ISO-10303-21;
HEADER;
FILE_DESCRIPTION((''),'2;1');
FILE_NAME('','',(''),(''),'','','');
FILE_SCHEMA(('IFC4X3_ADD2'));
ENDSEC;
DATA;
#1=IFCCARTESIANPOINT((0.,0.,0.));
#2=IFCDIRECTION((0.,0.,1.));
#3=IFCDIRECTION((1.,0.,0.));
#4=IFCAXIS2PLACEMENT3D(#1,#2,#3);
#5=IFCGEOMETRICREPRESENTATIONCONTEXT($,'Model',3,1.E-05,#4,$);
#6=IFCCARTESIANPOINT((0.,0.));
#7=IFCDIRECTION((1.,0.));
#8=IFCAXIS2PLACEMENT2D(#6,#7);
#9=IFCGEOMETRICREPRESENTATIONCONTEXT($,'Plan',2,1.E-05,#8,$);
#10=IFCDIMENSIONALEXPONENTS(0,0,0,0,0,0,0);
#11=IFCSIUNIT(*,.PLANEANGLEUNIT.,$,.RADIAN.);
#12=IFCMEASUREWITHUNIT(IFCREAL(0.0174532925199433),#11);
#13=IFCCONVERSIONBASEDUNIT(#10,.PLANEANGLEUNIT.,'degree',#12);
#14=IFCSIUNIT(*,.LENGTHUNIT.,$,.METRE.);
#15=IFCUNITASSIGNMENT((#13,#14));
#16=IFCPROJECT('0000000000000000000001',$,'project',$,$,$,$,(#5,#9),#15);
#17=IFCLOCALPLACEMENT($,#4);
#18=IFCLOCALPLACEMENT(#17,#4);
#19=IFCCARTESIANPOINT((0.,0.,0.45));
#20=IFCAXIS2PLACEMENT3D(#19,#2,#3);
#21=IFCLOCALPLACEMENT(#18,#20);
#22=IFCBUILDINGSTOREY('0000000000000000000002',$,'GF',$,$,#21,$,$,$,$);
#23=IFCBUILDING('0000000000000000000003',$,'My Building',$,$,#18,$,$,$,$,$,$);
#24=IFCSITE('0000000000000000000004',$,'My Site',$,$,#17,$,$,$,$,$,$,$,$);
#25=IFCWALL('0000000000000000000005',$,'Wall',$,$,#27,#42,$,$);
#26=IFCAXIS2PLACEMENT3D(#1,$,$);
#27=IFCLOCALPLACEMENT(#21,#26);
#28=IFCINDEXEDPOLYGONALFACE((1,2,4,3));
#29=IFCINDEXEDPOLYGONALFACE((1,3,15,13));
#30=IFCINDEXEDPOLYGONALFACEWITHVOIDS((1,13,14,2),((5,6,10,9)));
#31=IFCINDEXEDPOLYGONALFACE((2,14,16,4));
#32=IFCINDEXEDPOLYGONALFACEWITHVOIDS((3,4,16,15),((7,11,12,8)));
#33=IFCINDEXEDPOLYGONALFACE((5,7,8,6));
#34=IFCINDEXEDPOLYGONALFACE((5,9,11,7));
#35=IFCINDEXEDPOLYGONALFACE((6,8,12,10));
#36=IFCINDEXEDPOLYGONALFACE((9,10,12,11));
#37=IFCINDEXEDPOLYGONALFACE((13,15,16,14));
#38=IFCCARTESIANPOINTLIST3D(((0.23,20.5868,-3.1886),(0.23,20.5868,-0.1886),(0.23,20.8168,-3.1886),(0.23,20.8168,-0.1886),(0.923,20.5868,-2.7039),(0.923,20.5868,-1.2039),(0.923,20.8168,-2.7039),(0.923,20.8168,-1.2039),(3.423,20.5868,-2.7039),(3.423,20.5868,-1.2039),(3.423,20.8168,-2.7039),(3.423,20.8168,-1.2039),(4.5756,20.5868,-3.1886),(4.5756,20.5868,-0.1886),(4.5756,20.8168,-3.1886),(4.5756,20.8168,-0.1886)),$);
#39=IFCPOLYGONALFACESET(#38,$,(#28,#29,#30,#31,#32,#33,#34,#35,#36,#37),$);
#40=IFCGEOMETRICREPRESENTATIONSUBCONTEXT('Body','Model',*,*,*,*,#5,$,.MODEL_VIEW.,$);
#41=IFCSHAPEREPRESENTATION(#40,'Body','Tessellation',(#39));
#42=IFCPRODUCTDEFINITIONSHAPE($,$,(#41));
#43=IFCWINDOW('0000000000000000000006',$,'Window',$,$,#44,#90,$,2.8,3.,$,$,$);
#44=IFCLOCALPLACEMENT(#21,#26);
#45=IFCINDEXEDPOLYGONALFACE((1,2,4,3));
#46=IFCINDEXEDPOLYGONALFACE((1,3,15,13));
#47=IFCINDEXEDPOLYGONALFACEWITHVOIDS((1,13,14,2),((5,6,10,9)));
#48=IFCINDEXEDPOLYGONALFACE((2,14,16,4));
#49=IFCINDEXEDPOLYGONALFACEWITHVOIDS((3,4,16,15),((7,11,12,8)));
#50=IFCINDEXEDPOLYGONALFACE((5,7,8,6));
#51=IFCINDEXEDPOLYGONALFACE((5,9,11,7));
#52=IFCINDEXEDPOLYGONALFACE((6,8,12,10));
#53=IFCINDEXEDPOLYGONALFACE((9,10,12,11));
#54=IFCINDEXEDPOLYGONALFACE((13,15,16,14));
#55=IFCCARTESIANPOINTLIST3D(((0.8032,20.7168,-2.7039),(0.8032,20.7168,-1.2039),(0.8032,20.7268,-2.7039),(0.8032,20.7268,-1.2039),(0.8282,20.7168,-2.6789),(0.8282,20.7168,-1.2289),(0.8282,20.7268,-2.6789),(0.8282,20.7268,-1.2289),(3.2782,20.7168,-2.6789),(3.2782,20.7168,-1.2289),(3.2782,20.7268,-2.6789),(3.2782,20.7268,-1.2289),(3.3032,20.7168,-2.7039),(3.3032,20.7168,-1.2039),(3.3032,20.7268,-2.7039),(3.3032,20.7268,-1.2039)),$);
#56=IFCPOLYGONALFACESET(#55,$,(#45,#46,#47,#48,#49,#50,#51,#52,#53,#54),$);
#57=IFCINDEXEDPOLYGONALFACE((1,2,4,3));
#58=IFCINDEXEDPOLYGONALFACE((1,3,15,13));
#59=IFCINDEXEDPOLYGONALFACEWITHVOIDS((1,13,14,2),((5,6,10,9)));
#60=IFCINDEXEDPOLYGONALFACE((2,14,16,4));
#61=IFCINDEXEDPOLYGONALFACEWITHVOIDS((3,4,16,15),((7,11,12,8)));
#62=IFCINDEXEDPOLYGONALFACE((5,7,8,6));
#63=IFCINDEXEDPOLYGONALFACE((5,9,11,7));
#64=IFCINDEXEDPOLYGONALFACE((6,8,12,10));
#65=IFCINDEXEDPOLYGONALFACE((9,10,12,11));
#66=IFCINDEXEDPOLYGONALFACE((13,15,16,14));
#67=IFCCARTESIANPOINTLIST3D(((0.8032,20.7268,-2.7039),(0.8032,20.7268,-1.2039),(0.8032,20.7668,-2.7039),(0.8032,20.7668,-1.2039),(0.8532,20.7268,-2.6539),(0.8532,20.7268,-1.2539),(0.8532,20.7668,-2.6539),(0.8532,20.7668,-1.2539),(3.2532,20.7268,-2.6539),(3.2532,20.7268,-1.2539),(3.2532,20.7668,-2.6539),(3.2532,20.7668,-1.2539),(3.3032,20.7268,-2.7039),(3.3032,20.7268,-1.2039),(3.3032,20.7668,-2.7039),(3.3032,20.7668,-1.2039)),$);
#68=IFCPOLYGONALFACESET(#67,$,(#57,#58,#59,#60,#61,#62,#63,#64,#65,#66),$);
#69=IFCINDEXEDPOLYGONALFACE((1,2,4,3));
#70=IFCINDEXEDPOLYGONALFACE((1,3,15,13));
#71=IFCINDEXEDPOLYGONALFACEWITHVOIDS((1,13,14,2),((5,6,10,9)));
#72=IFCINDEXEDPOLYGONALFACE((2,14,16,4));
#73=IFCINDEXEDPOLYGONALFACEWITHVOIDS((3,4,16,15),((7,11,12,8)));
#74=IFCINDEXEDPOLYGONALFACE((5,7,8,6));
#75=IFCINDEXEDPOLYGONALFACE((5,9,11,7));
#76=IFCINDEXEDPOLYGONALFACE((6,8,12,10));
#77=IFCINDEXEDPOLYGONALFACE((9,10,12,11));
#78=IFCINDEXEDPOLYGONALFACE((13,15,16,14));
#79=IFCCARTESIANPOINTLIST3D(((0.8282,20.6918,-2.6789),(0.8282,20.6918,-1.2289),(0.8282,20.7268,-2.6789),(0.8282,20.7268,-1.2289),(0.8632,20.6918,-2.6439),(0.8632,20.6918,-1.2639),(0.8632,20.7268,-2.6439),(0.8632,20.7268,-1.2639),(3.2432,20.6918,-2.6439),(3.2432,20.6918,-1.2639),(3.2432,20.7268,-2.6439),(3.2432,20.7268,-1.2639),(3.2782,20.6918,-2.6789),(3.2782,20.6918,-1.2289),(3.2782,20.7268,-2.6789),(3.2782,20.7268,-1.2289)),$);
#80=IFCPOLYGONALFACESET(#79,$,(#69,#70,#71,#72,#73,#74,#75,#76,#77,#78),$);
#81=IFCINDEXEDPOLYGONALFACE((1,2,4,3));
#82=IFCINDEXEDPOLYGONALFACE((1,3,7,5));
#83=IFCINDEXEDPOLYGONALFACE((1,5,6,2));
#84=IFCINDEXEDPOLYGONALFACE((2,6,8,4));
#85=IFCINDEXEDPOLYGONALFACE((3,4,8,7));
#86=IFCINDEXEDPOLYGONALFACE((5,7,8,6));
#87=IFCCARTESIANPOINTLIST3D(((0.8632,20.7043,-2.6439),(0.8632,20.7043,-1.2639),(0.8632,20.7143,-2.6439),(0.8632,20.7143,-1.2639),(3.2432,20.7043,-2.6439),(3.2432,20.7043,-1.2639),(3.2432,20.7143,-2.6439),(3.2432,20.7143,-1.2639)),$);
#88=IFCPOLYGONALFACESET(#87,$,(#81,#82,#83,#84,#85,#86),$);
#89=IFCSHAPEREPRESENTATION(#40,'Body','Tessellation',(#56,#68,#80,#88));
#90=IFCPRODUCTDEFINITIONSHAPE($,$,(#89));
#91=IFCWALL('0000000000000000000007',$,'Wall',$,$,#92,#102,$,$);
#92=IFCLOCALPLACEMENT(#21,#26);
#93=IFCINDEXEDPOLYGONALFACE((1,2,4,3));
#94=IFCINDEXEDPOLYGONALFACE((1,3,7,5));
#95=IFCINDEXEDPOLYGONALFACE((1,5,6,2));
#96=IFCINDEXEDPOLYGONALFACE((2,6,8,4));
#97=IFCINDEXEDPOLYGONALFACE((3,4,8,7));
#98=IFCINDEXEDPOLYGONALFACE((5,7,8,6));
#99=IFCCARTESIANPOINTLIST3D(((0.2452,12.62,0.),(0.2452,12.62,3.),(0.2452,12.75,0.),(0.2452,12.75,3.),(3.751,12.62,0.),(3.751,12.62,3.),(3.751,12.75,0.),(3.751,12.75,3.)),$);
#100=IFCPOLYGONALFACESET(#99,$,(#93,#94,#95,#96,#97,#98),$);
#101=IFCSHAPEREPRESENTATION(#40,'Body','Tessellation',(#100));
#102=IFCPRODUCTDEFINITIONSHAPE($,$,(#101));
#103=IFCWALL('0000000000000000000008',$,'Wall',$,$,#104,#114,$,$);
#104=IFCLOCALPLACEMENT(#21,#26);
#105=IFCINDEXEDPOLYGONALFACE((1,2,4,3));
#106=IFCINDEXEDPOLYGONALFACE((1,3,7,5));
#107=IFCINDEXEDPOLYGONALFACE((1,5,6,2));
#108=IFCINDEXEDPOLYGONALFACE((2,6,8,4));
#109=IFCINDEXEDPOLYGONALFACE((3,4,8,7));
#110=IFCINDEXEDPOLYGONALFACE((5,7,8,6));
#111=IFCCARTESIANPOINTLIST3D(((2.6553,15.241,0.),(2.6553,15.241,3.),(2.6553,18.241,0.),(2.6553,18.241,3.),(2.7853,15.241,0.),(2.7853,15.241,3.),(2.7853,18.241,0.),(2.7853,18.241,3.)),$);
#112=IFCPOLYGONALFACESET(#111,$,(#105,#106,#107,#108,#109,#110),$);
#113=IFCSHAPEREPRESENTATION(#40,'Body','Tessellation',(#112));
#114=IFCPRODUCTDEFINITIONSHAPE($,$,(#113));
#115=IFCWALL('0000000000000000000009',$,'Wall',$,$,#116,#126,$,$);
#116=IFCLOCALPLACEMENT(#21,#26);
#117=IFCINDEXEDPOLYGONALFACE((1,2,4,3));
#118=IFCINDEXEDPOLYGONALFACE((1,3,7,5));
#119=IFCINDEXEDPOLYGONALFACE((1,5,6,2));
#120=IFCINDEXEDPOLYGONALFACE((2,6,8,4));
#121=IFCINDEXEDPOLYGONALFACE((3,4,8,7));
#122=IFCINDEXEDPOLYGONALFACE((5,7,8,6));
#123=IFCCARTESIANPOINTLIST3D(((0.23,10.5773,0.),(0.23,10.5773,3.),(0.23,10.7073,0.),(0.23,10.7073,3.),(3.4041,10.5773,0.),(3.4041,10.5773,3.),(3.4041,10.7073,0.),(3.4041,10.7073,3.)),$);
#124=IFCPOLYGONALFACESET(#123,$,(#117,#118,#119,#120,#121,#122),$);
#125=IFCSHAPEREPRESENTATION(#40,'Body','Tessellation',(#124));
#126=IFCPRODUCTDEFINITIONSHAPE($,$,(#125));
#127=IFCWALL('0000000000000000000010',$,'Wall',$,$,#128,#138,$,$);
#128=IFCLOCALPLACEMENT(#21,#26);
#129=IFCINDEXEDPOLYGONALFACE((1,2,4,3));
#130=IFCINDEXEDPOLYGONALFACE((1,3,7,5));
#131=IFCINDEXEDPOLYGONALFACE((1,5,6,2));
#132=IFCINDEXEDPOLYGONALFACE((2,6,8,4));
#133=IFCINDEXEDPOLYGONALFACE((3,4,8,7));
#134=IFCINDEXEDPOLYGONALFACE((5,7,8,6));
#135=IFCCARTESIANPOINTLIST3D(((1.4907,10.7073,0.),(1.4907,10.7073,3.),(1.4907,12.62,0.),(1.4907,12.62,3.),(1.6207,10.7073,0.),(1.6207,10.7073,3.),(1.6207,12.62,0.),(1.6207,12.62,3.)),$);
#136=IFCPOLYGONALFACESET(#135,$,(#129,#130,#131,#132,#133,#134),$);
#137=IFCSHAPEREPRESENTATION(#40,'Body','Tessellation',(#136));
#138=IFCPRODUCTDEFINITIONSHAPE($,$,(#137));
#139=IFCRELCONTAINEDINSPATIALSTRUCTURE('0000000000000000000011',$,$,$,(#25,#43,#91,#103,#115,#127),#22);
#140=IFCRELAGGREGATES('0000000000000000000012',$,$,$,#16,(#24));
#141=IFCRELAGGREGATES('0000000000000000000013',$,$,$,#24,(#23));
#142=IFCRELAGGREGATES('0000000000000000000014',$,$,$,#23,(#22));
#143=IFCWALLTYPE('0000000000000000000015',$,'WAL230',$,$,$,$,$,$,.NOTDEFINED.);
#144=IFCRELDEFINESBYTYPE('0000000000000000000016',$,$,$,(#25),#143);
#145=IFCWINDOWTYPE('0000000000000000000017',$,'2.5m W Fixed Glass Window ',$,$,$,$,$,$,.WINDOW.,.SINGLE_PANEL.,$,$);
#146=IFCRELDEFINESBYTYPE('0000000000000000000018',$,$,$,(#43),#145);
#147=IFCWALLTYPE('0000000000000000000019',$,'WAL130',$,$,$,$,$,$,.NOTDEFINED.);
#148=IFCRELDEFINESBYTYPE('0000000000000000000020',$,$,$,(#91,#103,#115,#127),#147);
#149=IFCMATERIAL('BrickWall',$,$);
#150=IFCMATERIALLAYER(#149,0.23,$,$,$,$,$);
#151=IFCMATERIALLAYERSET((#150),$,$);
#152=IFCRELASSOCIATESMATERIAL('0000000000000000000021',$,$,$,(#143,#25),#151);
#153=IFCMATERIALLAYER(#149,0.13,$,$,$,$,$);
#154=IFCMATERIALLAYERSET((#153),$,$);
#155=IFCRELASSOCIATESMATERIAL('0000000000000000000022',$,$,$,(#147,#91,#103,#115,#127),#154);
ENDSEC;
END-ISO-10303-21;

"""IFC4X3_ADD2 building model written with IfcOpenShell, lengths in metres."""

from ifc_helpers import new_model, entity, si_unit, converted_unit, frame, origin_with_axes, origin_2d_with_axis, place, context, subcontext, project, spatial, line, indexed_curve, outline, extrude, shape, source, transform, mapped, material, layer, layer_set, layer_usage, type_object, type_shapes, element, fill, save


model = new_model("IFC4X3_ADD2")

# Units and contexts
model_context = context("Model", 3, precision=1e-05, world=origin_with_axes())
plan_context = context("Plan", 2, precision=1e-05, world=origin_2d_with_axis())
body_context_1 = subcontext(model_context, "Body", "Model", "MODEL_VIEW")
body_context_2 = subcontext(plan_context, "Body", "Plan", "PLAN_VIEW")
ifc_project = project(units=[converted_unit("PLANEANGLEUNIT", "degree", entity("IfcReal", 0.0174532925199433), si_unit("PLANEANGLEUNIT", "RADIAN"), dimensions=[0, 0, 0, 0, 0, 0, 0]), si_unit("LENGTHUNIT", "METRE")], contexts=[model_context, plan_context])

# Site, building, storey
site_placement = place(None, origin_with_axes())
site = spatial("IfcSite", under=ifc_project, at=site_placement, Name="My Site")
building_placement = place(site_placement, origin_with_axes())
building = spatial("IfcBuilding", under=site, at=building_placement, Name="My Building")
storey_placement = place(building_placement, frame((0.0, 0.0, 0.45), z_axis=(0.0, 0.0, 1.0), x_axis=(1.0, 0.0, 0.0)))
storey = spatial("IfcBuildingStorey", under=building, at=storey_placement, Name="GF")

# Shared definitions
ifc_material_1 = material(Name="BrickWall")
ifc_layer_1 = layer(ifc_material_1, 0.23)
ifc_layer_set_1 = layer_set([ifc_layer_1])
wall_type_1 = type_object("IfcWallType", Name="WAL230", PredefinedType="NOTDEFINED", material=ifc_layer_set_1)
shared_shape_1 = source(origin_with_axes(), body_context_1, "Body", "SweptSolid", [
    extrude(outline(indexed_curve([(0.0, 0.0), (2.5, 0.0), (2.5, 1.5), (0.0, 1.5)], segments=[line(1, 2, 3, 4, 1)])), frame((0.0, -0.6, 0.0), z_axis=(0.0, -1.0, 0.0), x_axis=(1.0, 0.0, 0.0)), (0.0, 0.0, -1.0), 1.2),
])
window_type_1 = type_object("IfcWindowType", Name="2.5m W Fixed Glass Window ", PartitioningType="SINGLE_PANEL", PredefinedType="WINDOW")
shared_shape_2 = source(origin_with_axes(), body_context_1, "Body", "SweptSolid", [
    extrude(outline(indexed_curve([(0.0, 0.0), (2.5, 0.0), (2.5, 1.5), (0.0, 1.5)], segments=[line(1, 2, 3, 4, 1)]), holes=[indexed_curve([(0.025, 0.025), (2.475, 0.025), (2.475, 1.475), (0.025, 1.475)], segments=[line(1, 2, 3, 4, 1)])]), frame((0.0, 0.09, 0.0), z_axis=(0.0, -1.0, 0.0), x_axis=(1.0, 0.0, 0.0)), (0.0, 0.0, -1.0), 0.01),
    extrude(outline(indexed_curve([(0.0, 0.0), (2.5, 0.0), (2.5, 1.5), (0.0, 1.5)], segments=[line(1, 2, 3, 4, 1)]), holes=[indexed_curve([(0.05, 0.05), (2.45, 0.05), (2.45, 1.45), (0.05, 1.45)], segments=[line(1, 2, 3, 4, 1)])]), frame((0.0, 0.05, 0.0), z_axis=(0.0, -1.0, 0.0), x_axis=(1.0, 0.0, 0.0)), (0.0, 0.0, -1.0), 0.04),
    extrude(outline(indexed_curve([(0.0, 0.0), (2.45, 0.0), (2.45, 1.45), (0.0, 1.45)], segments=[line(1, 2, 3, 4, 1)]), holes=[indexed_curve([(0.035, 0.035), (2.415, 0.035), (2.415, 1.415), (0.035, 1.415)], segments=[line(1, 2, 3, 4, 1)])]), frame((0.025, 0.09, 0.025), z_axis=(0.0, -1.0, 0.0), x_axis=(1.0, 0.0, 0.0)), (0.0, 0.0, -1.0), 0.035),
    extrude(outline(indexed_curve([(0.035, 0.035), (2.415, 0.035), (2.415, 1.415), (0.035, 1.415)], segments=[line(1, 2, 3, 4, 1)])), frame((0.025, 0.1025, 0.025), z_axis=(0.0, -1.0, 0.0), x_axis=(1.0, 0.0, 0.0)), (0.0, 0.0, -1.0), 0.01),
])
shared_shape_3 = source(origin_with_axes(), body_context_2, "Body", "Curve2D", [
    entity("IfcIndexedPolyCurve", entity("IfcCartesianPointList2D", [[0.05, 0.05], [2.45, 0.05]])),
    entity("IfcIndexedPolyCurve", entity("IfcCartesianPointList2D", [[0.0, 0.1], [0.025, 0.1], [0.025, 0.09], [0.05, 0.09], [0.05, 0.05], [0.0, 0.05]]), [entity("IfcLineIndex", [1, 2, 3, 4, 5, 6, 1])]),
    entity("IfcIndexedPolyCurve", entity("IfcCartesianPointList2D", [[2.5, 0.1], [2.475, 0.1], [2.475, 0.09], [2.45, 0.09], [2.45, 0.05], [2.5, 0.05]]), [entity("IfcLineIndex", [1, 2, 3, 4, 5, 6, 1])]),
    entity("IfcIndexedPolyCurve", entity("IfcCartesianPointList2D", [[0.025, 0.09], [0.06, 0.09], [0.06, 0.125], [0.025, 0.125]]), [entity("IfcLineIndex", [1, 2, 3, 4, 1])]),
    entity("IfcIndexedPolyCurve", entity("IfcCartesianPointList2D", [[2.475, 0.09], [2.44, 0.09], [2.44, 0.125], [2.475, 0.125]]), [entity("IfcLineIndex", [1, 2, 3, 4, 1])]),
    entity("IfcIndexedPolyCurve", entity("IfcCartesianPointList2D", [[0.06, 0.09], [2.44, 0.09]])),
    entity("IfcIndexedPolyCurve", entity("IfcCartesianPointList2D", [[0.06, 0.125], [2.44, 0.125]])),
    entity("IfcIndexedPolyCurve", entity("IfcCartesianPointList2D", [[0.06, 0.1075], [2.44, 0.1075]])),
])
type_shapes(window_type_1, [shared_shape_2, shared_shape_3])

# Wall, opening, window
ifc_layer_usage_1 = layer_usage(ifc_layer_set_1, "AXIS2", "POSITIVE", 0.0)
wall_1_placement = place(storey_placement, frame((4.5756, 20.8168, -3.1886), z_axis=(0.0, 0.0, 1.0), x_axis=(-1.0, 0.0, 0.0)))
wall_1 = element("IfcWall", 1, at=wall_1_placement, inside=storey, type_object=wall_type_1, material=ifc_layer_usage_1, Name="Wall", context=body_context_1, shape_type="SweptSolid", body=[
    extrude(outline(indexed_curve([(0.0, 0.0), (0.0, 0.23), (4.3456, 0.23), (4.3456, 0.0), (0.0, 0.0)], self_intersect=False)), origin_with_axes(), (0.0, 0.0, 1.0), 3.0),
])
opening_1_placement = place(wall_1_placement, frame((1.1526, 0.0, 0.4847), z_axis=(0.0, 0.0, 1.0), x_axis=(1.0, 0.0, 0.0)))
opening_1 = element("IfcOpeningElement", 2, at=opening_1_placement, cuts=wall_1, PredefinedType="OPENING", context=body_context_1, shape_type="MappedRepresentation", body=[
    mapped(shared_shape_1, transform((0.0, 0.0, 0.0), x_axis=(1.0, 0.0, 0.0), y_axis=(0.0, 1.0, 0.0), z_axis=(0.0, 0.0, 1.0), scale=1.0)),
])
window_1_placement = place(opening_1_placement, frame((0.1197, 0.0, 0.0), z_axis=(0.0, 0.0, 1.0), x_axis=(1.0, 0.0, 0.0)))
window_1 = element("IfcWindow", 3, at=window_1_placement, inside=storey, type_object=window_type_1, Name="Window", OverallHeight=2.8, OverallWidth=3.0, shapes=[
    shape(body_context_1, "Body", "MappedRepresentation", [mapped(shared_shape_2, transform((0.0, 0.0, 0.0), x_axis=(1.0, 0.0, 0.0), y_axis=(0.0, 1.0, 0.0), z_axis=(0.0, 0.0, 1.0), scale=1.0))]),
    shape(body_context_2, "Body", "MappedRepresentation", [mapped(shared_shape_3, transform((0.0, 0.0, 0.0), x_axis=(1.0, 0.0, 0.0), y_axis=(0.0, 1.0, 0.0), z_axis=(0.0, 0.0, 1.0), scale=1.0))]),
])
fill(opening_1, window_1)

# Walls
ifc_layer_2 = layer(ifc_material_1, 0.13)
ifc_layer_set_2 = layer_set([ifc_layer_2])
ifc_layer_usage_2 = layer_usage(ifc_layer_set_2, "AXIS2", "POSITIVE", 0.0)
wall_type_2 = type_object("IfcWallType", Name="WAL130", PredefinedType="NOTDEFINED", material=ifc_layer_set_2)
wall_2_placement = place(storey_placement, frame((0.2452, 12.62, 0.0), z_axis=(0.0, 0.0, 1.0), x_axis=(1.0, 0.0, 0.0)))
element("IfcWall", 4, at=wall_2_placement, inside=storey, type_object=wall_type_2, material=ifc_layer_usage_2, Name="Wall", context=body_context_1, shape_type="SweptSolid", body=[
    extrude(outline(indexed_curve([(0.0, 0.0), (0.0, 0.13), (3.5058, 0.13), (3.5058, 0.0), (0.0, 0.0)], self_intersect=False)), origin_with_axes(), (0.0, 0.0, 1.0), 3.0),
])
ifc_layer_usage_3 = layer_usage(ifc_layer_set_2, "AXIS2", "POSITIVE", 0.0)
wall_3_placement = place(storey_placement, frame((2.7853, 15.241, 0.0), z_axis=(0.0, 0.0, 1.0), x_axis=(0.0, 1.0, 0.0)))
element("IfcWall", 5, at=wall_3_placement, inside=storey, type_object=wall_type_2, material=ifc_layer_usage_3, Name="Wall", context=body_context_1, shape_type="SweptSolid", body=[
    extrude(outline(indexed_curve([(0.0, 0.0), (0.0, 0.13), (3.0, 0.13), (3.0, 0.0), (0.0, 0.0)], self_intersect=False)), origin_with_axes(), (0.0, 0.0, 1.0), 3.0),
])
ifc_layer_usage_4 = layer_usage(ifc_layer_set_2, "AXIS2", "POSITIVE", 0.0)
wall_4_placement = place(storey_placement, frame((0.23, 10.5773, 0.0), z_axis=(0.0, 0.0, 1.0), x_axis=(1.0, 0.0, 0.0)))
element("IfcWall", 6, at=wall_4_placement, inside=storey, type_object=wall_type_2, material=ifc_layer_usage_4, Name="Wall", context=body_context_1, shape_type="SweptSolid", body=[
    extrude(outline(indexed_curve([(0.0, 0.0), (0.0, 0.13), (3.1741, 0.13), (3.1741, 0.0), (0.0, 0.0)], self_intersect=False)), origin_with_axes(), (0.0, 0.0, 1.0), 3.0),
])
ifc_layer_usage_5 = layer_usage(ifc_layer_set_2, "AXIS2", "POSITIVE", 0.0)
wall_5_placement = place(storey_placement, frame((1.6207, 10.7073, 0.0), z_axis=(0.0, 0.0, 1.0), x_axis=(0.0, 1.0, 0.0)))
element("IfcWall", 7, at=wall_5_placement, inside=storey, type_object=wall_type_2, material=ifc_layer_usage_5, Name="Wall", context=body_context_1, shape_type="SweptSolid", body=[
    extrude(outline(indexed_curve([(0.0, 0.0), (0.0, 0.13), (1.9127, 0.13), (1.9127, 0.0), (0.0, 0.0)], self_intersect=False)), origin_with_axes(), (0.0, 0.0, 1.0), 3.0),
])

save(model, "model.ifc")
